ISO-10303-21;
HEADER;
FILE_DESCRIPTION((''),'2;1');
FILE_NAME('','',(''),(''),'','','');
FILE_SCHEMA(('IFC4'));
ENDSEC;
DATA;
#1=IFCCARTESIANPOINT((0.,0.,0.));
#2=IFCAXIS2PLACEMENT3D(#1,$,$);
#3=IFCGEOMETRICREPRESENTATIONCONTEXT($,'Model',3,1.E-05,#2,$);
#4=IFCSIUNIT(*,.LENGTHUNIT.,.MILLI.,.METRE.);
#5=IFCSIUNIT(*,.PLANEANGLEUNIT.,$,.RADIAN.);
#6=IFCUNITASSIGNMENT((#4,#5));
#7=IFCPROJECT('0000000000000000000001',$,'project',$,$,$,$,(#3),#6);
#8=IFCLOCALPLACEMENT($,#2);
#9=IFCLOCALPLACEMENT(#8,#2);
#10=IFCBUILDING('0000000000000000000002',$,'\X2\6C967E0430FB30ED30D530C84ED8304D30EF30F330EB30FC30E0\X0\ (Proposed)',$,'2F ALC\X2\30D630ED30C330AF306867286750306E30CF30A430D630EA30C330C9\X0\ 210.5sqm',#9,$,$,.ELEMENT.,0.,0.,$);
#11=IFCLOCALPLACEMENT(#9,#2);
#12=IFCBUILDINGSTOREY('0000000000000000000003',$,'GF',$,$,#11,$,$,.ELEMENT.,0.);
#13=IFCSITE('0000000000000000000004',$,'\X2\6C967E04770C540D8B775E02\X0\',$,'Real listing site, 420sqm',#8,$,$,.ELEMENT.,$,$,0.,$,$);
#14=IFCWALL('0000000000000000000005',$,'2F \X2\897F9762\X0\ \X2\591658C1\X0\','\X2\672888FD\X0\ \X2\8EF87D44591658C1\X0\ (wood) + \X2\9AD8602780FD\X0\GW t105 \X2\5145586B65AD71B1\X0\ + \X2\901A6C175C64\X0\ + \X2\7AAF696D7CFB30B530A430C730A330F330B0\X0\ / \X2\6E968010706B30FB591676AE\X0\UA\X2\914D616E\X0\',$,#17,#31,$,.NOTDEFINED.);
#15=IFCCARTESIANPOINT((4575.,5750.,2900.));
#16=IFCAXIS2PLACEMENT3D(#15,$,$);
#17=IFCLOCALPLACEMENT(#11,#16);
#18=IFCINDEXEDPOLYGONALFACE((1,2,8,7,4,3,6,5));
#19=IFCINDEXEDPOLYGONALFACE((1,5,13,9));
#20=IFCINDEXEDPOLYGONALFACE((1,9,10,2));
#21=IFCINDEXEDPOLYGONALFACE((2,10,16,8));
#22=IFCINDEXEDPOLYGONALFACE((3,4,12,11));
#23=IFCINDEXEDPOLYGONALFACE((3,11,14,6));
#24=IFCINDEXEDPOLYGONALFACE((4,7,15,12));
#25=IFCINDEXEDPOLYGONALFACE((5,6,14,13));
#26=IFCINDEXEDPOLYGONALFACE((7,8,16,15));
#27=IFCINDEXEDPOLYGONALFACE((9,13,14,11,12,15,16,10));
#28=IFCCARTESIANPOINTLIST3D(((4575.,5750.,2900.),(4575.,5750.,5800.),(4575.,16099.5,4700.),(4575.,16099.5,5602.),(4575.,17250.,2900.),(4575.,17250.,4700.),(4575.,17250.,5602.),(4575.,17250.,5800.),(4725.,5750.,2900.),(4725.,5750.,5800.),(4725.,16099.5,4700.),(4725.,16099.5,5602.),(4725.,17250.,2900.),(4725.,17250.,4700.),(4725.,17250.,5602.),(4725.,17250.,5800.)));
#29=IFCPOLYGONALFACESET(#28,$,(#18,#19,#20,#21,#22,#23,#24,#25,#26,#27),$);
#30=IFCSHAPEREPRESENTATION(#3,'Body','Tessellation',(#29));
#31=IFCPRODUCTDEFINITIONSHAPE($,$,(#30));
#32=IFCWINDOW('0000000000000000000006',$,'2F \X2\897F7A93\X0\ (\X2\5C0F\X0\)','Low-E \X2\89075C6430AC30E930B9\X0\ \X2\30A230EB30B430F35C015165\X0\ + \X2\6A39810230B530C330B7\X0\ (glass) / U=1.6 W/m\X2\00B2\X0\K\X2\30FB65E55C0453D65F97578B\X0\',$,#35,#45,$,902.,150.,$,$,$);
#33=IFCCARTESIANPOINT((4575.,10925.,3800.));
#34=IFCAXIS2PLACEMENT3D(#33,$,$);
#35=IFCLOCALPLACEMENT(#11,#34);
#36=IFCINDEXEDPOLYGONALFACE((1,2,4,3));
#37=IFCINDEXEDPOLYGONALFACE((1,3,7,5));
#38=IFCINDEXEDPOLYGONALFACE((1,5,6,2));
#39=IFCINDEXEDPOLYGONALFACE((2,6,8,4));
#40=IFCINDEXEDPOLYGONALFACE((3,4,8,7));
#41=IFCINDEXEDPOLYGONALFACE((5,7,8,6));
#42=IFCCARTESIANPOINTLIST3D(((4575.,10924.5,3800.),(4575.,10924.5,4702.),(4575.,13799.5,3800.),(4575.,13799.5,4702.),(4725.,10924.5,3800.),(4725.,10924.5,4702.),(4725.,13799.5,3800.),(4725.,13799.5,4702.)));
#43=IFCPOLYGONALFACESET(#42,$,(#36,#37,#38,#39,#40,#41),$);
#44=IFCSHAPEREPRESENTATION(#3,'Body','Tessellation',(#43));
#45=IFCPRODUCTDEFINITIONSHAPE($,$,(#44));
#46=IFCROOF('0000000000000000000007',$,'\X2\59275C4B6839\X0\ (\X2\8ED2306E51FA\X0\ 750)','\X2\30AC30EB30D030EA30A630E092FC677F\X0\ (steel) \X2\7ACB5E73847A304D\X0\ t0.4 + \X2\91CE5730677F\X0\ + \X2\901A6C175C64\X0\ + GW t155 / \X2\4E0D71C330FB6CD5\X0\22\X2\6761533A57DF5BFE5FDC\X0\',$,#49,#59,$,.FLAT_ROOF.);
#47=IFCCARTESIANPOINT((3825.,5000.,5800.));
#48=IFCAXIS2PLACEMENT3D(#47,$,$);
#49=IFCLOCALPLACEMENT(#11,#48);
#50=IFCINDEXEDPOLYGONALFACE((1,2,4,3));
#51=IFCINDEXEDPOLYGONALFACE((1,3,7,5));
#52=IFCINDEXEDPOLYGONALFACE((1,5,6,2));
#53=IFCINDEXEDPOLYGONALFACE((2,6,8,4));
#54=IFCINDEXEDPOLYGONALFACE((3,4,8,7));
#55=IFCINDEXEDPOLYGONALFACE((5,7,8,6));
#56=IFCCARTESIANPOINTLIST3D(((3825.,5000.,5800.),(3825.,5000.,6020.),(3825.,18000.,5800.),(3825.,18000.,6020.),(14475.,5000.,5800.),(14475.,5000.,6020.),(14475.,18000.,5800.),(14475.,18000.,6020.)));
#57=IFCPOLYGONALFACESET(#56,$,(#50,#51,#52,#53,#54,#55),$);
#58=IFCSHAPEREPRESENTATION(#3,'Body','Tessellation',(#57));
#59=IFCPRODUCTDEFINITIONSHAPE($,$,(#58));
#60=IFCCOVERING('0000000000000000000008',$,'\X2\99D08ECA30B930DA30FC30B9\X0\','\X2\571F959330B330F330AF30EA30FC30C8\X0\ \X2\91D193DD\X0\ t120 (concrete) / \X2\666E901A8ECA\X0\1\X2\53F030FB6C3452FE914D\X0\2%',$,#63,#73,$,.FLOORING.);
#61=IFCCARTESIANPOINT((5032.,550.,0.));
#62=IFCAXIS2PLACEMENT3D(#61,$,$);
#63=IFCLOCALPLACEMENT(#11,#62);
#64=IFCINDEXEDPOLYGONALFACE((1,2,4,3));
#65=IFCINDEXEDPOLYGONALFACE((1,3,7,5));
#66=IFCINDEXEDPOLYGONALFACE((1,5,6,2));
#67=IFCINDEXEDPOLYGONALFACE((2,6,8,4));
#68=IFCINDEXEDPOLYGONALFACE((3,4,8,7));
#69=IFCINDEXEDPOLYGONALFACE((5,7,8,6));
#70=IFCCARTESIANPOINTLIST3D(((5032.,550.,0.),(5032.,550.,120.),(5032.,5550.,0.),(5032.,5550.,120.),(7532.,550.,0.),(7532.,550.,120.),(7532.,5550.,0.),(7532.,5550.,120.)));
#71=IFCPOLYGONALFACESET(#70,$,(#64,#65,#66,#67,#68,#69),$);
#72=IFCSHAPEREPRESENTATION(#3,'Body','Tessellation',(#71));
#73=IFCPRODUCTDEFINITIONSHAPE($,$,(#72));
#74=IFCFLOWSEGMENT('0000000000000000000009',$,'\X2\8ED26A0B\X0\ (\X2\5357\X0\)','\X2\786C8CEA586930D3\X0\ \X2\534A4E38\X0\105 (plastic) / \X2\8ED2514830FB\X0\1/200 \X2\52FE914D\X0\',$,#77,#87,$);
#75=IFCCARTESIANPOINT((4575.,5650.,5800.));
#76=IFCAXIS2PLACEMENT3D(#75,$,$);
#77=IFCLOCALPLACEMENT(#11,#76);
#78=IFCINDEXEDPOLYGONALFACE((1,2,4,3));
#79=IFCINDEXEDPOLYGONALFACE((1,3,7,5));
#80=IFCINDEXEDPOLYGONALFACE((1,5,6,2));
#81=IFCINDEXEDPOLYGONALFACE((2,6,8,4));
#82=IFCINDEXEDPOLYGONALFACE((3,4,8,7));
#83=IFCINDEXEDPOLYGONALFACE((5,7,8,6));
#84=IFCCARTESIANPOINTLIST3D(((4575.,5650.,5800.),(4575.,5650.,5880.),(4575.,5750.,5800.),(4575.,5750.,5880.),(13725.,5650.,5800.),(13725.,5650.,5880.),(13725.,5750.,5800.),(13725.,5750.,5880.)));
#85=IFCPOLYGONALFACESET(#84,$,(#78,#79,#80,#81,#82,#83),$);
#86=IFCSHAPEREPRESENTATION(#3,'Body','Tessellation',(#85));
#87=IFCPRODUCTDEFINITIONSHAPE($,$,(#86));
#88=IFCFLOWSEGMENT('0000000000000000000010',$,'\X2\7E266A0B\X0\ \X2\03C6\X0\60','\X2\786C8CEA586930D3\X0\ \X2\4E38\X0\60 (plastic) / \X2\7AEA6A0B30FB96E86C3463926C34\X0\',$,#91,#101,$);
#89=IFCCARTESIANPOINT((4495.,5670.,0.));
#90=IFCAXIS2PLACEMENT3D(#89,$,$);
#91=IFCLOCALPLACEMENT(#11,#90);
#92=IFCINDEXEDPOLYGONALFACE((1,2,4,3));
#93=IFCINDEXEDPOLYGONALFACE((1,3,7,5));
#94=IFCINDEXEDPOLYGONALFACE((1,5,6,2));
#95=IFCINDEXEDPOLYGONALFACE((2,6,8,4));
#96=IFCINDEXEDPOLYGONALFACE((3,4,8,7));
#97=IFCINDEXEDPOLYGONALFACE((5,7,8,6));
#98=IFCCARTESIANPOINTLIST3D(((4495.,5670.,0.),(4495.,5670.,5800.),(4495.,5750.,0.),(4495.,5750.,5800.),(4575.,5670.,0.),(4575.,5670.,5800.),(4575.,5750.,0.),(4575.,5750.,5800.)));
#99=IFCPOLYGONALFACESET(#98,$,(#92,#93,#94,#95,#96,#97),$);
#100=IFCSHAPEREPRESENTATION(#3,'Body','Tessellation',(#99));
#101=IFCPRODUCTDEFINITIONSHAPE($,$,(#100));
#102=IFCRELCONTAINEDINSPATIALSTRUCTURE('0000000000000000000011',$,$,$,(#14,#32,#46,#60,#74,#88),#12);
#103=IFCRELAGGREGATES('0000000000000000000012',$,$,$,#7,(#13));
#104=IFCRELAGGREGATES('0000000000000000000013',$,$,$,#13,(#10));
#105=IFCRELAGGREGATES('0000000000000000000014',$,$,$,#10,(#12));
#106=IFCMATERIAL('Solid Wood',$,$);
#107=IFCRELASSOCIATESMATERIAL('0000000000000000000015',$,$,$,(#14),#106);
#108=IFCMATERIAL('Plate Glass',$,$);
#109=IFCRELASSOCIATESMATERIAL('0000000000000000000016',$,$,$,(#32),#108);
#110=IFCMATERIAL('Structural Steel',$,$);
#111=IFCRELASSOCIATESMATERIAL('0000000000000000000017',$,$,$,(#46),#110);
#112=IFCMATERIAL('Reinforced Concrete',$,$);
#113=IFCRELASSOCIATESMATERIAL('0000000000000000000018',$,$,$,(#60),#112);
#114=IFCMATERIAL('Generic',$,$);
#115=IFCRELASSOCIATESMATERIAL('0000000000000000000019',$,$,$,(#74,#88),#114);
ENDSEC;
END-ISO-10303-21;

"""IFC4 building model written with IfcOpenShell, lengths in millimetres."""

from ifc_helpers import new_model, si_unit, frame, frame_2d, origin, place, context, project, spatial, rectangle, extrude, material, element, fill, save


model = new_model("IFC4")

# Units and contexts
model_context = context("Model", 3, precision=1e-05, world=origin())
ifc_project = project(units=[si_unit("LENGTHUNIT", "METRE", prefix="MILLI"), si_unit("PLANEANGLEUNIT", "RADIAN")], contexts=[model_context])

# Site, building, storey
site_placement = place(None, origin())
site = spatial("IfcSite", under=ifc_project, at=site_placement, Name="沖縄県名護市", ObjectType="Real listing site, 420sqm", CompositionType="ELEMENT", RefElevation=0.0)
building_placement = place(site_placement, origin())
building = spatial("IfcBuilding", under=site, at=building_placement, Name="沖縄・ロフト付きワンルーム (Proposed)", ObjectType="2F ALCブロックと木材のハイブリッド 210.5sqm", CompositionType="ELEMENT", ElevationOfRefHeight=0.0, ElevationOfTerrain=0.0)
storey_placement = place(building_placement, origin())
storey = spatial("IfcBuildingStorey", under=building, at=storey_placement, Name="GF", CompositionType="ELEMENT", Elevation=0.0)

# Shared definitions
ifc_material_1 = material(Name="Solid Wood")

# Shared definitions
ifc_material_2 = material(Name="Reinforced Concrete")

# Shared definitions
ifc_material_3 = material(Name="Plate Glass")

# Wall, opening, window
wall_1_placement = place(storey_placement, frame((4575.0, 5750.0, 2900.0)))
wall_1 = element("IfcWall", 1, at=wall_1_placement, inside=storey, material=ifc_material_1, Name="2F 西面 外壁", Description="木製 軸組外壁 (wood) + 高性能GW t105 充填断熱 + 通気層 + 窯業系サイディング / 準耐火・外皮UA配慮", PredefinedType="NOTDEFINED", context=model_context, shape_type="SweptSolid", body=[
    extrude(rectangle(XDim=150.0, YDim=11500.0, at=frame_2d((75.0, 5750.0))), frame((4575.0, 5750.0, 2900.0)), (0.0, 0.0, 1.0), 2900.0),
])
opening_1_placement = place(storey_placement, frame((4575.0, 10925.0, 3800.0)))
opening_1 = element("IfcOpeningElement", 2, at=opening_1_placement, cuts=wall_1, PredefinedType="NOTDEFINED", context=model_context, shape_type="SweptSolid", body=[
    extrude(rectangle(XDim=150.0, YDim=2875.0, at=frame_2d((75.0, 1437.0))), frame((4575.0, 10925.0, 3800.0)), (0.0, 0.0, 1.0), 902.0),
])
window_1_placement = place(storey_placement, frame((4575.0, 10925.0, 3800.0)))
window_1 = element("IfcWindow", 3, at=window_1_placement, inside=storey, material=ifc_material_3, Name="2F 西窓 (小)", Description="Low-E 複層ガラス アルゴン封入 + 樹脂サッシ (glass) / U=1.6 W/m²K・日射取得型", OverallHeight=902.0, OverallWidth=150.0, context=model_context, shape_type="SweptSolid", body=[
    extrude(rectangle(XDim=150.0, YDim=2875.0, at=frame_2d((75.0, 1437.0))), frame((4575.0, 10925.0, 3800.0)), (0.0, 0.0, 1.0), 902.0),
])
fill(opening_1, window_1)

# Roof
ifc_material_4 = material(Name="Structural Steel")
roof_placement = place(storey_placement, frame((3825.0, 5000.0, 5800.0)))
element("IfcRoof", 4, at=roof_placement, inside=storey, material=ifc_material_4, Name="大屋根 (軒の出 750)", Description="ガルバリウム鋼板 (steel) 立平葺き t0.4 + 野地板 + 通気層 + GW t155 / 不燃・法22条区域対応", PredefinedType="FLAT_ROOF", context=model_context, shape_type="SweptSolid", body=[
    extrude(rectangle(XDim=10650.0, YDim=13000.0, at=frame_2d((5325.0, 6500.0))), frame((3825.0, 5000.0, 5800.0)), (0.0, 0.0, 1.0), 220.0),
])

# Covering
covering_placement = place(storey_placement, frame((5032.0, 550.0, 0.0)))
element("IfcCovering", 5, at=covering_placement, inside=storey, material=ifc_material_2, Name="駐車スペース", Description="土間コンクリート 金鏝 t120 (concrete) / 普通車1台・水勾配2%", PredefinedType="FLOORING", context=model_context, shape_type="SweptSolid", body=[
    extrude(rectangle(XDim=2500.0, YDim=5000.0, at=frame_2d((1250.0, 2500.0))), frame((5032.0, 550.0, 0.0)), (0.0, 0.0, 1.0), 120.0),
])

# Flow segments
ifc_material_5 = material(Name="Generic")
flow_segment_1_placement = place(storey_placement, frame((4575.0, 5650.0, 5800.0)))
element("IfcFlowSegment", 6, at=flow_segment_1_placement, inside=storey, material=ifc_material_5, Name="軒樋 (南)", Description="硬質塩ビ 半丸105 (plastic) / 軒先・1/200 勾配", context=model_context, shape_type="SweptSolid", body=[
    extrude(rectangle(XDim=9150.0, YDim=100.0, at=frame_2d((4575.0, 50.0))), frame((4575.0, 5650.0, 5800.0)), (0.0, 0.0, 1.0), 80.0),
])
flow_segment_2_placement = place(storey_placement, frame((4495.0, 5670.0, 0.0)))
element("IfcFlowSegment", 7, at=flow_segment_2_placement, inside=storey, material=ifc_material_5, Name="縦樋 φ60", Description="硬質塩ビ 丸60 (plastic) / 竪樋・雨水排水", context=model_context, shape_type="SweptSolid", body=[
    extrude(rectangle(XDim=80.0, YDim=80.0, at=frame_2d((40.0, 40.0))), frame((4495.0, 5670.0, 0.0)), (0.0, 0.0, 1.0), 5800.0),
])

save(model, "model.ifc")
